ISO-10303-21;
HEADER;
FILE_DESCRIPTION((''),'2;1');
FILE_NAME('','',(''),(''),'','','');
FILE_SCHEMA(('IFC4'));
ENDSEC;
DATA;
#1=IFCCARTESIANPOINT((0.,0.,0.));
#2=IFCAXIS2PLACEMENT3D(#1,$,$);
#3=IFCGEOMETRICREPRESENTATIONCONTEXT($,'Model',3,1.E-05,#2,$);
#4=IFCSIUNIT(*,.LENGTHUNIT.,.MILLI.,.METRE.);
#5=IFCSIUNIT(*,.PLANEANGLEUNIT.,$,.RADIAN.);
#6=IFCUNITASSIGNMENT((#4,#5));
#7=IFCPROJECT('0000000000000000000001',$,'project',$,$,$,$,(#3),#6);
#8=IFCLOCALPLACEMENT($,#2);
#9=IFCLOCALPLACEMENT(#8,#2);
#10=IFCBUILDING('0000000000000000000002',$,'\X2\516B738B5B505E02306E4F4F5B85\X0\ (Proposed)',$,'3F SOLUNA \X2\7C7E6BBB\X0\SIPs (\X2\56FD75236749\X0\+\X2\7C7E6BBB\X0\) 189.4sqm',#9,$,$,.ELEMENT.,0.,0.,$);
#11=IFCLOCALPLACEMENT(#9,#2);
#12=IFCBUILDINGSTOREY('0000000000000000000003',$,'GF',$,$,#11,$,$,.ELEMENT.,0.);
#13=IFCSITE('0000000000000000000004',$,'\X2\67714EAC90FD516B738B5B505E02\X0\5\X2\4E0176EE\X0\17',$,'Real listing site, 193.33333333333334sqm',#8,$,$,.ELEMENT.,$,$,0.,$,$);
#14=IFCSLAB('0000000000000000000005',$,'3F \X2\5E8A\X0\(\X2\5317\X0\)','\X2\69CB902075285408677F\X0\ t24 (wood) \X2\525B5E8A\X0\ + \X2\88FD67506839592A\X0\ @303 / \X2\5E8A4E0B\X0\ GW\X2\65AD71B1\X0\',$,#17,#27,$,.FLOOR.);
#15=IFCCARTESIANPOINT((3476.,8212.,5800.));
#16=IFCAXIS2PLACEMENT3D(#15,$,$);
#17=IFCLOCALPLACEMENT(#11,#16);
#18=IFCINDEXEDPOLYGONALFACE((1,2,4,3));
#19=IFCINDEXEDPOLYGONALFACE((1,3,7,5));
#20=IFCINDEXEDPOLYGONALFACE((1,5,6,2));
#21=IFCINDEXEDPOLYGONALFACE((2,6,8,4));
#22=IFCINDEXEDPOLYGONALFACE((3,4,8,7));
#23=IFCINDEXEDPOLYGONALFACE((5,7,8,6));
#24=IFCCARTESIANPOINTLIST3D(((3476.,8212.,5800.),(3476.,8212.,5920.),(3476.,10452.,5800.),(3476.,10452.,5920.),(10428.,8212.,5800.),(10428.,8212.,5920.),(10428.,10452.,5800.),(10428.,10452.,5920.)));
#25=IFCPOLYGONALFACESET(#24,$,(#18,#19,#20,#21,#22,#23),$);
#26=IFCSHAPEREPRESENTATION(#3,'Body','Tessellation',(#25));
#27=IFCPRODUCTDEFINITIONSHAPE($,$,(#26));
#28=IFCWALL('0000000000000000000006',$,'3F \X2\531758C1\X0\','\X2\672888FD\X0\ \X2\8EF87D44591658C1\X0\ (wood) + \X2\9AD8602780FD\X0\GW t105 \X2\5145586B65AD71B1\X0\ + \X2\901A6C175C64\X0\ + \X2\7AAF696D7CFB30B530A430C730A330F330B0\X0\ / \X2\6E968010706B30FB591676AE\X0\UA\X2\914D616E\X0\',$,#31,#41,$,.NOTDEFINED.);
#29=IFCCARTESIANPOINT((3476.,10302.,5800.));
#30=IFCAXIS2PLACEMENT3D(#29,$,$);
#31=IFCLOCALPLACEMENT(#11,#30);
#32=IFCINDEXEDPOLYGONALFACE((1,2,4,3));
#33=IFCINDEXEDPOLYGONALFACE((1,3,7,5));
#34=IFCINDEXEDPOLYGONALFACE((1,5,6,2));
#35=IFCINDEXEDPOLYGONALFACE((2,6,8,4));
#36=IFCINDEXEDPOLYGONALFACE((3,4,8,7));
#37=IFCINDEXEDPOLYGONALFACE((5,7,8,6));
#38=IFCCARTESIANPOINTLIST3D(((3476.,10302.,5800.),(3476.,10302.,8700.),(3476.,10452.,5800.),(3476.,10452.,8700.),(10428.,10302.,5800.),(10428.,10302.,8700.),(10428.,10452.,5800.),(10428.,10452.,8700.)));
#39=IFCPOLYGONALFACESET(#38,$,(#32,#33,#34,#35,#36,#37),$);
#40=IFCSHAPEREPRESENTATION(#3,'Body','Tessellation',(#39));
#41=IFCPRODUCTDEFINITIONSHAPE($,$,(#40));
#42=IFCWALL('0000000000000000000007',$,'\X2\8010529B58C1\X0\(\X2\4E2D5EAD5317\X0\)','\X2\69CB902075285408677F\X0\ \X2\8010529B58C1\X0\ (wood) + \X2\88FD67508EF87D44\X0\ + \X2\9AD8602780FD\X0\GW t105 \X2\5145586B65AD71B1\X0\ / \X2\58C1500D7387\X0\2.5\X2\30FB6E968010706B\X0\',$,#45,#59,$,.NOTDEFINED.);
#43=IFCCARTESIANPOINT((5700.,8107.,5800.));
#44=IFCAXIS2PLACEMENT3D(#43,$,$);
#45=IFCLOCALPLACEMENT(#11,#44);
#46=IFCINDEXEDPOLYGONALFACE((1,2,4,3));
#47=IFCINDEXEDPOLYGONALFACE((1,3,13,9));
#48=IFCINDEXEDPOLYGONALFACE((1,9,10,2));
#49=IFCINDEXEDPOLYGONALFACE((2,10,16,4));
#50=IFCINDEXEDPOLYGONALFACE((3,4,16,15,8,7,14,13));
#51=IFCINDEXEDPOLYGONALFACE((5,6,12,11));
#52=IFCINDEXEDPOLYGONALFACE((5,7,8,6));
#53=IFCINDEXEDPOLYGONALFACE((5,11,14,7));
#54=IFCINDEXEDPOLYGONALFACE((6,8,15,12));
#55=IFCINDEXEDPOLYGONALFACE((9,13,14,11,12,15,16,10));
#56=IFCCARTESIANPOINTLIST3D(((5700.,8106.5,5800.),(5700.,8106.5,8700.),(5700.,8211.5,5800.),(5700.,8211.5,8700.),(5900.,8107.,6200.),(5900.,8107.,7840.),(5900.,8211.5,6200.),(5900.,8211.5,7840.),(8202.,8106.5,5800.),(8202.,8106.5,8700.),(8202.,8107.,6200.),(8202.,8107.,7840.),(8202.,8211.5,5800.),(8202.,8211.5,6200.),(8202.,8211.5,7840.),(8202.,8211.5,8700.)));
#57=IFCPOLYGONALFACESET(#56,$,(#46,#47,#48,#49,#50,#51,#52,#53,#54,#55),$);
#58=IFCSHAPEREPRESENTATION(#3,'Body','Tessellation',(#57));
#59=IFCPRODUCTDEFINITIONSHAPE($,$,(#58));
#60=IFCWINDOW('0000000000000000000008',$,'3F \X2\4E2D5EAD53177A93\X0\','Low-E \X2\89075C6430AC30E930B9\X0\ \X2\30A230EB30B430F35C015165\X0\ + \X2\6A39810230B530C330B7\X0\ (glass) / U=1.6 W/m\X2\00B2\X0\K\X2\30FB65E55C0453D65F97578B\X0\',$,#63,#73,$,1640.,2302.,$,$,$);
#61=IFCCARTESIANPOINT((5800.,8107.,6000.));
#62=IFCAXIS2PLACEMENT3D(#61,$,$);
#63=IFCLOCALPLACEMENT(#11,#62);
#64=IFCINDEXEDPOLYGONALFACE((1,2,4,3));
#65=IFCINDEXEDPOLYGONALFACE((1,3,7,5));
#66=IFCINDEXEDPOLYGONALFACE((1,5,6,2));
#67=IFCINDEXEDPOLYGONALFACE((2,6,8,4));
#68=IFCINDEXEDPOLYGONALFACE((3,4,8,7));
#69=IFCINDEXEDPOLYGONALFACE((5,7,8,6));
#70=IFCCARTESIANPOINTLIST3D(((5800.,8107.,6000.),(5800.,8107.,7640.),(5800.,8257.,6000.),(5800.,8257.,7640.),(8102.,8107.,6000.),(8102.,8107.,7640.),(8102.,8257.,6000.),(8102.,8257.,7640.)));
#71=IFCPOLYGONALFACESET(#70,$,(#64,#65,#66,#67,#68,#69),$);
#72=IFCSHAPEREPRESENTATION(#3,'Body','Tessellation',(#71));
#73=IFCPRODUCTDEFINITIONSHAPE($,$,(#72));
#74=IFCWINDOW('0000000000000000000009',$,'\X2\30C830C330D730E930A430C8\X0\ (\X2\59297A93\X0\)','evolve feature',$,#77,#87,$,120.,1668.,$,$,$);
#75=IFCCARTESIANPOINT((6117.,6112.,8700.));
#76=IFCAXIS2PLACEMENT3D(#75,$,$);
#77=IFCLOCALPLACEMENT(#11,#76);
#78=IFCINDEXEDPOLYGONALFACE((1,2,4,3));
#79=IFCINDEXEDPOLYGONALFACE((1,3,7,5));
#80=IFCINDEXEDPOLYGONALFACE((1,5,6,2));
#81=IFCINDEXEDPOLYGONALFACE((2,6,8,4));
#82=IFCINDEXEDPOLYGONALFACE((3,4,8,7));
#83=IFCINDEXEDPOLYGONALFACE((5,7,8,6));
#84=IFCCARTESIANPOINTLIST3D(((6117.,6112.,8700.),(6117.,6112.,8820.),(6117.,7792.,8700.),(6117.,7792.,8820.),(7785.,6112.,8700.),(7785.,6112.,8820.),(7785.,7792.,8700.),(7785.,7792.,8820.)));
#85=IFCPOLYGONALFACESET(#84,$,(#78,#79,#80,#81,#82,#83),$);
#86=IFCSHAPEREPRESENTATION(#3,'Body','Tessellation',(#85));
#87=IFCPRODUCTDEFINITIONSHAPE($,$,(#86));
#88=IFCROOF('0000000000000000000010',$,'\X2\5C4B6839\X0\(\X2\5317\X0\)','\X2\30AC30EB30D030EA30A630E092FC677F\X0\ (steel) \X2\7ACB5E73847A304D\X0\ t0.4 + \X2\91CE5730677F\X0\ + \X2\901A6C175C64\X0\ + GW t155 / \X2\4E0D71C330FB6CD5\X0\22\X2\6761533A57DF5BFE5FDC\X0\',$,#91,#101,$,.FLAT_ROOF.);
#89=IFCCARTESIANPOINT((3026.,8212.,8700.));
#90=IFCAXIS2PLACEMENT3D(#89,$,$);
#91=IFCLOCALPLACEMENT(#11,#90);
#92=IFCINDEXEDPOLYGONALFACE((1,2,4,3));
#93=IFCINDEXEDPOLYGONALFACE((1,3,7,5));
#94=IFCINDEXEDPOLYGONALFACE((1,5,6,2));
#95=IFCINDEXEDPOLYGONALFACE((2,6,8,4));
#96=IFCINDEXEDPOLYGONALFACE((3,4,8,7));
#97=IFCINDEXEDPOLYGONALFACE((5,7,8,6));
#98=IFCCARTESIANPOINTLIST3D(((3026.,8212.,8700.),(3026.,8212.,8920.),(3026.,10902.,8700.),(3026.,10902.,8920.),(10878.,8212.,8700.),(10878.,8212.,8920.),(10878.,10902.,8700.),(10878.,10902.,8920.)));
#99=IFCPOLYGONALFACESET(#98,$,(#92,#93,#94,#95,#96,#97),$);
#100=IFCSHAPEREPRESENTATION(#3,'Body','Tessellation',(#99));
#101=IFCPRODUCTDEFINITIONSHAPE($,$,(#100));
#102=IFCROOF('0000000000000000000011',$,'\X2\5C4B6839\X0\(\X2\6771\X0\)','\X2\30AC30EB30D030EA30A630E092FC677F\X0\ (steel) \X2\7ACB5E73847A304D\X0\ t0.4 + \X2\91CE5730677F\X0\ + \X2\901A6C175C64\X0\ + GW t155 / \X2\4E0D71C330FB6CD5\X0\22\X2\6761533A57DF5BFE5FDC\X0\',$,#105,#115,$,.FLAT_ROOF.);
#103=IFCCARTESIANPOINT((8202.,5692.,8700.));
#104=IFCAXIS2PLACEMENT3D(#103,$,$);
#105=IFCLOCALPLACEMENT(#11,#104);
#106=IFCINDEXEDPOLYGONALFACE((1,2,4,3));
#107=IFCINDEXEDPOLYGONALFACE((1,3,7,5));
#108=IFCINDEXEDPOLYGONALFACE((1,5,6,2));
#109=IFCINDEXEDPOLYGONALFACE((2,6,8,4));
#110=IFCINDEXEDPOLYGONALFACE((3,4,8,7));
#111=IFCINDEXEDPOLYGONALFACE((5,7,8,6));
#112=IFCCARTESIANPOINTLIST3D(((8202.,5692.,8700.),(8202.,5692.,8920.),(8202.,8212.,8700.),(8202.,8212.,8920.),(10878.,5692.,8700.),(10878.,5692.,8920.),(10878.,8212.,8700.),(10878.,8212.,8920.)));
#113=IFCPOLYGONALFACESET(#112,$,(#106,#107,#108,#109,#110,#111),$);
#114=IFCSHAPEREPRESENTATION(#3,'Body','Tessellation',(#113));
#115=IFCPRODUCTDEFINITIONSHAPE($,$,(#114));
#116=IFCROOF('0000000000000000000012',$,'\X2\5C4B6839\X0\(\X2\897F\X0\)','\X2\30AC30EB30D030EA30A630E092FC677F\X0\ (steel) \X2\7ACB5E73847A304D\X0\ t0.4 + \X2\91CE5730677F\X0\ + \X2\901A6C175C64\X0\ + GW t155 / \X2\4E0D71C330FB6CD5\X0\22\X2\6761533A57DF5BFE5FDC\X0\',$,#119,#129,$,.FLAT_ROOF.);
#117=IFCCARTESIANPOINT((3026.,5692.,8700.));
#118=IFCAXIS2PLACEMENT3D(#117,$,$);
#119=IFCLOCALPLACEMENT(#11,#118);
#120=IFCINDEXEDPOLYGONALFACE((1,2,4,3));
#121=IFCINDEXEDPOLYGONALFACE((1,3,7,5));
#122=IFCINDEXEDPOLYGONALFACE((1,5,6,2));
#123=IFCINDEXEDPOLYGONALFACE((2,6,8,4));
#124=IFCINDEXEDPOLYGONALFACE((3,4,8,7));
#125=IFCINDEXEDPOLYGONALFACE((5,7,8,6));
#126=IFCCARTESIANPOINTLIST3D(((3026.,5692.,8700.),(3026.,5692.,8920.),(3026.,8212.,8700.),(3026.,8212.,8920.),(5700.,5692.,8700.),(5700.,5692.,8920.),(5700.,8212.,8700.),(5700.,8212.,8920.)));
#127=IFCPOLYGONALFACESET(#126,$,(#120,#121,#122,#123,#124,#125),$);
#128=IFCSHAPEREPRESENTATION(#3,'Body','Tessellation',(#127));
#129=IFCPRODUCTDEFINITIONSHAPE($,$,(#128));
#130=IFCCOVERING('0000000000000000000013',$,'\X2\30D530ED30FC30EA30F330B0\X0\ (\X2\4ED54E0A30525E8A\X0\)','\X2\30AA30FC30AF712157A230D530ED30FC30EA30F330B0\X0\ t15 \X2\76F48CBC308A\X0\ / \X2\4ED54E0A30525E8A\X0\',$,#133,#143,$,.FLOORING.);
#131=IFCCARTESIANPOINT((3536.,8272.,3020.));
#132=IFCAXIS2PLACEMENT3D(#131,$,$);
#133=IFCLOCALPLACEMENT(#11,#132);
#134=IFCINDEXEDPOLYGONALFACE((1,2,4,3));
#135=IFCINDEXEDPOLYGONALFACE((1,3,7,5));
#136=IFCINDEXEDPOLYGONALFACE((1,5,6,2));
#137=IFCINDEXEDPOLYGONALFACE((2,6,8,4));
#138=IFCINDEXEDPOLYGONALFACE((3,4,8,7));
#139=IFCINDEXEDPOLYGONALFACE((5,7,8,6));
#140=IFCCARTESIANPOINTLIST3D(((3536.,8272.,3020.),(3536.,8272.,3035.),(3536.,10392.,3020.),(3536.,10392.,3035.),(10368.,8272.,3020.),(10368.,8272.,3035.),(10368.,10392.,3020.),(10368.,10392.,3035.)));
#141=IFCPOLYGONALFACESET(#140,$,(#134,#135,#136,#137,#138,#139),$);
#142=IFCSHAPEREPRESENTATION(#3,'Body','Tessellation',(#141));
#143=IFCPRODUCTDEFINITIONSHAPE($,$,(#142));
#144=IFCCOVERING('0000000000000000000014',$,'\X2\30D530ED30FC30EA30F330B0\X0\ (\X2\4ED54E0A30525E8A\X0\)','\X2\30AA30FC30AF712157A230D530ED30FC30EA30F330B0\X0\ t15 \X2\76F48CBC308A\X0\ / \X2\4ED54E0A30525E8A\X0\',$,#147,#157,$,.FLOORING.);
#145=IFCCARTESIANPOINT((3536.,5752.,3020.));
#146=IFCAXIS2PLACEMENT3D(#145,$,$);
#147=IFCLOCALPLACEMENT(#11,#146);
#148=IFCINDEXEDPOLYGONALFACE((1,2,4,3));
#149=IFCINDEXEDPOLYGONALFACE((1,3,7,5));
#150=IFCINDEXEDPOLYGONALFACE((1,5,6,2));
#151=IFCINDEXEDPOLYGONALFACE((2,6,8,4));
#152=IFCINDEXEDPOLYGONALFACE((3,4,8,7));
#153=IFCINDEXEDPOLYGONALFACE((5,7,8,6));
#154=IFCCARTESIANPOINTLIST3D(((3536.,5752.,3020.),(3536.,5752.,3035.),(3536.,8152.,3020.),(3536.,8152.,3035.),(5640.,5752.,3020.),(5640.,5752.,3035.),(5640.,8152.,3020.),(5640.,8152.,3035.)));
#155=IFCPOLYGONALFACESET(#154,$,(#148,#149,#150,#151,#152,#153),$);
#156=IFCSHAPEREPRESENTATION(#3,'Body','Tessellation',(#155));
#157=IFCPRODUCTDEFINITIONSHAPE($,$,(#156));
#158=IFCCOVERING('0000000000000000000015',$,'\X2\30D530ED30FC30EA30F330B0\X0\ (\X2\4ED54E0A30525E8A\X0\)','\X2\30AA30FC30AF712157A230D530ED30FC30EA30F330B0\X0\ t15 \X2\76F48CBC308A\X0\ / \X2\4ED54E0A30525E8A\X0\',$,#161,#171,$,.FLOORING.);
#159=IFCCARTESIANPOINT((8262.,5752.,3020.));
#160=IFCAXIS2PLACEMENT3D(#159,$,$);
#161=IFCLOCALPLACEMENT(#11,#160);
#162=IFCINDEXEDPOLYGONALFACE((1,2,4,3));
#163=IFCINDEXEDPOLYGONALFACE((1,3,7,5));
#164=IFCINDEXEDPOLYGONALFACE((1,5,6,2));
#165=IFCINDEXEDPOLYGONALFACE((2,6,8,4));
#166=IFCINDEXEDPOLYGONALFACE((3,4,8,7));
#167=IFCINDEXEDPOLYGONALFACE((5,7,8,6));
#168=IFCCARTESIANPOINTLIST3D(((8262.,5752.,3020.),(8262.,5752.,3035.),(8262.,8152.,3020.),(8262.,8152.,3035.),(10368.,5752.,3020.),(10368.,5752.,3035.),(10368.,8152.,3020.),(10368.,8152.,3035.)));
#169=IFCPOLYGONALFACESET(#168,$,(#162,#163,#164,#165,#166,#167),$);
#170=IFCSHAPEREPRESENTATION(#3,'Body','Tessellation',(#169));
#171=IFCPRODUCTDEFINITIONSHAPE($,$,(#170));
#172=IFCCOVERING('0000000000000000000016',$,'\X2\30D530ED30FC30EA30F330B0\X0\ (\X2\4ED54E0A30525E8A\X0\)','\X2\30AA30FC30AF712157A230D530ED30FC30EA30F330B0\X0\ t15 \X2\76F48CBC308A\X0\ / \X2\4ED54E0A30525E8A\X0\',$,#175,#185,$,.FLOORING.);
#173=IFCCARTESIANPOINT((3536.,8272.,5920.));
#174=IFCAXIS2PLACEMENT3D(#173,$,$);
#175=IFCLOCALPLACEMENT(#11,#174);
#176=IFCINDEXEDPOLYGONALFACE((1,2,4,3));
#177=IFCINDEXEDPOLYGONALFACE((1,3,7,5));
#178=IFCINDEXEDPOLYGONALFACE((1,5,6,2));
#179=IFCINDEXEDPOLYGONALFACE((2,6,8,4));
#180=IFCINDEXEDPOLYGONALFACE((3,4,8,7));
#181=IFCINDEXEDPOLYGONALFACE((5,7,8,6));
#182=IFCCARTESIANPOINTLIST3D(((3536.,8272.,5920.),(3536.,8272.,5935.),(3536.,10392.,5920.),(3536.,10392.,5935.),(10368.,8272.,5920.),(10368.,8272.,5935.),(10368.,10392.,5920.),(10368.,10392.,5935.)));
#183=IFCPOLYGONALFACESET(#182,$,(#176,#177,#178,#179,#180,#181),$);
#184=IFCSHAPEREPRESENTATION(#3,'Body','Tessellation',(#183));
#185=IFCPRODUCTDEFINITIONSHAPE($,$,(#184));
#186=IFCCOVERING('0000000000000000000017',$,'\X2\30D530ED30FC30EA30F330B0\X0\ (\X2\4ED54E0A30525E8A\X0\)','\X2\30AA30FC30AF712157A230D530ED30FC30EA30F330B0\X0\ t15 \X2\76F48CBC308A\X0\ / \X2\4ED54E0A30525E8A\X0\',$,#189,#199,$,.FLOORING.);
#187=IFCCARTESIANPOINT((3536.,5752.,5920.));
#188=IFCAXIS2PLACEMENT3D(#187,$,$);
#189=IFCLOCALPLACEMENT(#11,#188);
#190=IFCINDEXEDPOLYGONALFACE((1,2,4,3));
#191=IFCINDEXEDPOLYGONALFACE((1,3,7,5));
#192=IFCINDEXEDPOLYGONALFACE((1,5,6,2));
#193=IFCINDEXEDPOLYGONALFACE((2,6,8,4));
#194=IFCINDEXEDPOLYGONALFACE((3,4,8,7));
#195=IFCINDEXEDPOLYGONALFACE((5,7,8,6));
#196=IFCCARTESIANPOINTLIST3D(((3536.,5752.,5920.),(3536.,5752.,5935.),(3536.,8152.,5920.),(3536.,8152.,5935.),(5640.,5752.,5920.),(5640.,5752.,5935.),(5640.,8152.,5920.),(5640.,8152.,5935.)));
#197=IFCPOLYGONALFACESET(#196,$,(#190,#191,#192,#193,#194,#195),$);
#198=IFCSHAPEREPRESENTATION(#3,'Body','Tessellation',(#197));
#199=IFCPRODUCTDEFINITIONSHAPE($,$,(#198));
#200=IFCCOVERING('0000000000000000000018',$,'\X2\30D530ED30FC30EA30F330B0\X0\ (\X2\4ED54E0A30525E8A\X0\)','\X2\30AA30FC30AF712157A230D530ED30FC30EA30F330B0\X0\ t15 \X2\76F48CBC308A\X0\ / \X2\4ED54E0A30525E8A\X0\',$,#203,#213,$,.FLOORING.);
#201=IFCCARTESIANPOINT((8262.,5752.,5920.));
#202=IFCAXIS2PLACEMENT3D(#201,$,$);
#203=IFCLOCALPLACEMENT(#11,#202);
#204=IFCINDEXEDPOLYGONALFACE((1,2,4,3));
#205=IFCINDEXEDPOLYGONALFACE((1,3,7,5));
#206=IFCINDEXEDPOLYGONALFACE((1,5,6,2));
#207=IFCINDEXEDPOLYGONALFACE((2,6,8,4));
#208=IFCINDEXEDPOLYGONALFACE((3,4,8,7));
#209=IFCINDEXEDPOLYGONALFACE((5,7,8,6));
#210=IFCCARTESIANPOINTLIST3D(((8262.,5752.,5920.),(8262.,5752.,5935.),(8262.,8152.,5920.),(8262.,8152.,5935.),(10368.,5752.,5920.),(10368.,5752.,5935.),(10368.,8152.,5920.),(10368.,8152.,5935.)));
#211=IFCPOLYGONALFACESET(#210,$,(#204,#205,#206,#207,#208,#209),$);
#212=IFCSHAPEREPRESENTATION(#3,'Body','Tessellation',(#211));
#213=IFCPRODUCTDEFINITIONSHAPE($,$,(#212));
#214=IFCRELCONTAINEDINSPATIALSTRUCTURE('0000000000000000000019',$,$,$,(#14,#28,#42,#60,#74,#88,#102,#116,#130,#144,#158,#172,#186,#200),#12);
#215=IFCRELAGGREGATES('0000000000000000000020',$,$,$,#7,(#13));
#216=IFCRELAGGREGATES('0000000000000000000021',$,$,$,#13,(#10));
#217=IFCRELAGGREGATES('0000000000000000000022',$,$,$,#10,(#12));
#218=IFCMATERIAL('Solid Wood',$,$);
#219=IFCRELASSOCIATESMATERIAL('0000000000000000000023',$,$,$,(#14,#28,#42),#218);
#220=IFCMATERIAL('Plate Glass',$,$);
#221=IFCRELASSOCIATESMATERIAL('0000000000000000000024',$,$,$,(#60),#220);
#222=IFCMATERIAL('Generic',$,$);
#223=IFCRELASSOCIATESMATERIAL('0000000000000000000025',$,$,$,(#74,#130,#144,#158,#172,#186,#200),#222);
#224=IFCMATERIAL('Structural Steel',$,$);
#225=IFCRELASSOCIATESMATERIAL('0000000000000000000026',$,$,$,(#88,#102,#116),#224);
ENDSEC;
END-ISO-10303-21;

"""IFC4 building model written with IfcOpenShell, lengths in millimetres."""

from ifc_helpers import new_model, si_unit, frame, frame_2d, origin, place, context, project, spatial, rectangle, extrude, material, element, fill, save


model = new_model("IFC4")

# Units and contexts
model_context = context("Model", 3, precision=1e-05, world=origin())
ifc_project = project(units=[si_unit("LENGTHUNIT", "METRE", prefix="MILLI"), si_unit("PLANEANGLEUNIT", "RADIAN")], contexts=[model_context])

# Site, building, storey
site_placement = place(None, origin())
site = spatial("IfcSite", under=ifc_project, at=site_placement, Name="東京都八王子市5丁目17", ObjectType="Real listing site, 193.33333333333334sqm", CompositionType="ELEMENT", RefElevation=0.0)
building_placement = place(site_placement, origin())
building = spatial("IfcBuilding", under=site, at=building_placement, Name="八王子市の住宅 (Proposed)", ObjectType="3F SOLUNA 籾殻SIPs (国産杉+籾殻) 189.4sqm", CompositionType="ELEMENT", ElevationOfRefHeight=0.0, ElevationOfTerrain=0.0)
storey_placement = place(building_placement, origin())
storey = spatial("IfcBuildingStorey", under=building, at=storey_placement, Name="GF", CompositionType="ELEMENT", Elevation=0.0)

# Slab
ifc_material_1 = material(Name="Solid Wood")
slab_placement = place(storey_placement, frame((3476.0, 8212.0, 5800.0)))
element("IfcSlab", 1, at=slab_placement, inside=storey, material=ifc_material_1, Name="3F 床(北)", Description="構造用合板 t24 (wood) 剛床 + 製材根太 @303 / 床下 GW断熱", PredefinedType="FLOOR", context=model_context, shape_type="SweptSolid", body=[
    extrude(rectangle(XDim=6952.0, YDim=2240.0, at=frame_2d((3476.0, 1120.0))), frame((3476.0, 8212.0, 5800.0)), (0.0, 0.0, 1.0), 120.0),
])

# Wall
wall_1_placement = place(storey_placement, frame((3476.0, 10302.0, 5800.0)))
element("IfcWall", 2, at=wall_1_placement, inside=storey, material=ifc_material_1, Name="3F 北壁", Description="木製 軸組外壁 (wood) + 高性能GW t105 充填断熱 + 通気層 + 窯業系サイディング / 準耐火・外皮UA配慮", PredefinedType="NOTDEFINED", context=model_context, shape_type="SweptSolid", body=[
    extrude(rectangle(XDim=6952.0, YDim=150.0, at=frame_2d((3476.0, 75.0))), frame((3476.0, 10302.0, 5800.0)), (0.0, 0.0, 1.0), 2900.0),
])

# Wall, opening, window
wall_2_placement = place(storey_placement, frame((5700.0, 8107.0, 5800.0)))
wall_2 = element("IfcWall", 3, at=wall_2_placement, inside=storey, material=ifc_material_1, Name="耐力壁(中庭北)", Description="構造用合板 耐力壁 (wood) + 製材軸組 + 高性能GW t105 充填断熱 / 壁倍率2.5・準耐火", PredefinedType="NOTDEFINED", context=model_context, shape_type="SweptSolid", body=[
    extrude(rectangle(XDim=2502.0, YDim=105.0, at=frame_2d((1251.0, 52.0))), frame((5700.0, 8107.0, 5800.0)), (0.0, 0.0, 1.0), 2900.0),
])
opening_placement = place(storey_placement, frame((5800.0, 8107.0, 6000.0)))
opening = element("IfcOpeningElement", 4, at=opening_placement, cuts=wall_2, PredefinedType="NOTDEFINED", context=model_context, shape_type="SweptSolid", body=[
    extrude(rectangle(XDim=2302.0, YDim=150.0, at=frame_2d((1151.0, 75.0))), frame((5800.0, 8107.0, 6000.0)), (0.0, 0.0, 1.0), 1640.0),
])
ifc_material_2 = material(Name="Plate Glass")
window_1_placement = place(storey_placement, frame((5800.0, 8107.0, 6000.0)))
window_1 = element("IfcWindow", 5, at=window_1_placement, inside=storey, material=ifc_material_2, Name="3F 中庭北窓", Description="Low-E 複層ガラス アルゴン封入 + 樹脂サッシ (glass) / U=1.6 W/m²K・日射取得型", OverallHeight=1640.0, OverallWidth=2302.0, context=model_context, shape_type="SweptSolid", body=[
    extrude(rectangle(XDim=2302.0, YDim=150.0, at=frame_2d((1151.0, 75.0))), frame((5800.0, 8107.0, 6000.0)), (0.0, 0.0, 1.0), 1640.0),
])
fill(opening, window_1)

# Window
ifc_material_3 = material(Name="Generic")
window_2_placement = place(storey_placement, frame((6117.0, 6112.0, 8700.0)))
element("IfcWindow", 6, at=window_2_placement, inside=storey, material=ifc_material_3, Name="トップライト (天窓)", Description="evolve feature", OverallHeight=120.0, OverallWidth=1668.0, context=model_context, shape_type="SweptSolid", body=[
    extrude(rectangle(XDim=1668.0, YDim=1680.0, at=frame_2d((834.0, 840.0))), frame((6117.0, 6112.0, 8700.0)), (0.0, 0.0, 1.0), 120.0),
])

# Roofs
ifc_material_4 = material(Name="Structural Steel")
roof_1_placement = place(storey_placement, frame((3026.0, 8212.0, 8700.0)))
element("IfcRoof", 7, at=roof_1_placement, inside=storey, material=ifc_material_4, Name="屋根(北)", Description="ガルバリウム鋼板 (steel) 立平葺き t0.4 + 野地板 + 通気層 + GW t155 / 不燃・法22条区域対応", PredefinedType="FLAT_ROOF", context=model_context, shape_type="SweptSolid", body=[
    extrude(rectangle(XDim=7852.0, YDim=2690.0, at=frame_2d((3926.0, 1345.0))), frame((3026.0, 8212.0, 8700.0)), (0.0, 0.0, 1.0), 220.0),
])
roof_2_placement = place(storey_placement, frame((8202.0, 5692.0, 8700.0)))
element("IfcRoof", 8, at=roof_2_placement, inside=storey, material=ifc_material_4, Name="屋根(東)", Description="ガルバリウム鋼板 (steel) 立平葺き t0.4 + 野地板 + 通気層 + GW t155 / 不燃・法22条区域対応", PredefinedType="FLAT_ROOF", context=model_context, shape_type="SweptSolid", body=[
    extrude(rectangle(XDim=2676.0, YDim=2520.0, at=frame_2d((1338.0, 1260.0))), frame((8202.0, 5692.0, 8700.0)), (0.0, 0.0, 1.0), 220.0),
])
roof_3_placement = place(storey_placement, frame((3026.0, 5692.0, 8700.0)))
element("IfcRoof", 9, at=roof_3_placement, inside=storey, material=ifc_material_4, Name="屋根(西)", Description="ガルバリウム鋼板 (steel) 立平葺き t0.4 + 野地板 + 通気層 + GW t155 / 不燃・法22条区域対応", PredefinedType="FLAT_ROOF", context=model_context, shape_type="SweptSolid", body=[
    extrude(rectangle(XDim=2674.0, YDim=2520.0, at=frame_2d((1337.0, 1260.0))), frame((3026.0, 5692.0, 8700.0)), (0.0, 0.0, 1.0), 220.0),
])

# Coverings
covering_1_placement = place(storey_placement, frame((3536.0, 8272.0, 3020.0)))
element("IfcCovering", 10, at=covering_1_placement, inside=storey, material=ifc_material_3, Name="フローリング (仕上げ床)", Description="オーク無垢フローリング t15 直貼り / 仕上げ床", PredefinedType="FLOORING", context=model_context, shape_type="SweptSolid", body=[
    extrude(rectangle(XDim=6832.0, YDim=2120.0, at=frame_2d((3416.0, 1060.0))), frame((3536.0, 8272.0, 3020.0)), (0.0, 0.0, 1.0), 15.0),
])
covering_2_placement = place(storey_placement, frame((3536.0, 5752.0, 3020.0)))
element("IfcCovering", 11, at=covering_2_placement, inside=storey, material=ifc_material_3, Name="フローリング (仕上げ床)", Description="オーク無垢フローリング t15 直貼り / 仕上げ床", PredefinedType="FLOORING", context=model_context, shape_type="SweptSolid", body=[
    extrude(rectangle(XDim=2104.0, YDim=2400.0, at=frame_2d((1052.0, 1200.0))), frame((3536.0, 5752.0, 3020.0)), (0.0, 0.0, 1.0), 15.0),
])
covering_3_placement = place(storey_placement, frame((8262.0, 5752.0, 3020.0)))
element("IfcCovering", 12, at=covering_3_placement, inside=storey, material=ifc_material_3, Name="フローリング (仕上げ床)", Description="オーク無垢フローリング t15 直貼り / 仕上げ床", PredefinedType="FLOORING", context=model_context, shape_type="SweptSolid", body=[
    extrude(rectangle(XDim=2106.0, YDim=2400.0, at=frame_2d((1053.0, 1200.0))), frame((8262.0, 5752.0, 3020.0)), (0.0, 0.0, 1.0), 15.0),
])
covering_4_placement = place(storey_placement, frame((3536.0, 8272.0, 5920.0)))
element("IfcCovering", 13, at=covering_4_placement, inside=storey, material=ifc_material_3, Name="フローリング (仕上げ床)", Description="オーク無垢フローリング t15 直貼り / 仕上げ床", PredefinedType="FLOORING", context=model_context, shape_type="SweptSolid", body=[
    extrude(rectangle(XDim=6832.0, YDim=2120.0, at=frame_2d((3416.0, 1060.0))), frame((3536.0, 8272.0, 5920.0)), (0.0, 0.0, 1.0), 15.0),
])
covering_5_placement = place(storey_placement, frame((3536.0, 5752.0, 5920.0)))
element("IfcCovering", 14, at=covering_5_placement, inside=storey, material=ifc_material_3, Name="フローリング (仕上げ床)", Description="オーク無垢フローリング t15 直貼り / 仕上げ床", PredefinedType="FLOORING", context=model_context, shape_type="SweptSolid", body=[
    extrude(rectangle(XDim=2104.0, YDim=2400.0, at=frame_2d((1052.0, 1200.0))), frame((3536.0, 5752.0, 5920.0)), (0.0, 0.0, 1.0), 15.0),
])
covering_6_placement = place(storey_placement, frame((8262.0, 5752.0, 5920.0)))
element("IfcCovering", 15, at=covering_6_placement, inside=storey, material=ifc_material_3, Name="フローリング (仕上げ床)", Description="オーク無垢フローリング t15 直貼り / 仕上げ床", PredefinedType="FLOORING", context=model_context, shape_type="SweptSolid", body=[
    extrude(rectangle(XDim=2106.0, YDim=2400.0, at=frame_2d((1053.0, 1200.0))), frame((8262.0, 5752.0, 5920.0)), (0.0, 0.0, 1.0), 15.0),
])

save(model, "model.ifc")
